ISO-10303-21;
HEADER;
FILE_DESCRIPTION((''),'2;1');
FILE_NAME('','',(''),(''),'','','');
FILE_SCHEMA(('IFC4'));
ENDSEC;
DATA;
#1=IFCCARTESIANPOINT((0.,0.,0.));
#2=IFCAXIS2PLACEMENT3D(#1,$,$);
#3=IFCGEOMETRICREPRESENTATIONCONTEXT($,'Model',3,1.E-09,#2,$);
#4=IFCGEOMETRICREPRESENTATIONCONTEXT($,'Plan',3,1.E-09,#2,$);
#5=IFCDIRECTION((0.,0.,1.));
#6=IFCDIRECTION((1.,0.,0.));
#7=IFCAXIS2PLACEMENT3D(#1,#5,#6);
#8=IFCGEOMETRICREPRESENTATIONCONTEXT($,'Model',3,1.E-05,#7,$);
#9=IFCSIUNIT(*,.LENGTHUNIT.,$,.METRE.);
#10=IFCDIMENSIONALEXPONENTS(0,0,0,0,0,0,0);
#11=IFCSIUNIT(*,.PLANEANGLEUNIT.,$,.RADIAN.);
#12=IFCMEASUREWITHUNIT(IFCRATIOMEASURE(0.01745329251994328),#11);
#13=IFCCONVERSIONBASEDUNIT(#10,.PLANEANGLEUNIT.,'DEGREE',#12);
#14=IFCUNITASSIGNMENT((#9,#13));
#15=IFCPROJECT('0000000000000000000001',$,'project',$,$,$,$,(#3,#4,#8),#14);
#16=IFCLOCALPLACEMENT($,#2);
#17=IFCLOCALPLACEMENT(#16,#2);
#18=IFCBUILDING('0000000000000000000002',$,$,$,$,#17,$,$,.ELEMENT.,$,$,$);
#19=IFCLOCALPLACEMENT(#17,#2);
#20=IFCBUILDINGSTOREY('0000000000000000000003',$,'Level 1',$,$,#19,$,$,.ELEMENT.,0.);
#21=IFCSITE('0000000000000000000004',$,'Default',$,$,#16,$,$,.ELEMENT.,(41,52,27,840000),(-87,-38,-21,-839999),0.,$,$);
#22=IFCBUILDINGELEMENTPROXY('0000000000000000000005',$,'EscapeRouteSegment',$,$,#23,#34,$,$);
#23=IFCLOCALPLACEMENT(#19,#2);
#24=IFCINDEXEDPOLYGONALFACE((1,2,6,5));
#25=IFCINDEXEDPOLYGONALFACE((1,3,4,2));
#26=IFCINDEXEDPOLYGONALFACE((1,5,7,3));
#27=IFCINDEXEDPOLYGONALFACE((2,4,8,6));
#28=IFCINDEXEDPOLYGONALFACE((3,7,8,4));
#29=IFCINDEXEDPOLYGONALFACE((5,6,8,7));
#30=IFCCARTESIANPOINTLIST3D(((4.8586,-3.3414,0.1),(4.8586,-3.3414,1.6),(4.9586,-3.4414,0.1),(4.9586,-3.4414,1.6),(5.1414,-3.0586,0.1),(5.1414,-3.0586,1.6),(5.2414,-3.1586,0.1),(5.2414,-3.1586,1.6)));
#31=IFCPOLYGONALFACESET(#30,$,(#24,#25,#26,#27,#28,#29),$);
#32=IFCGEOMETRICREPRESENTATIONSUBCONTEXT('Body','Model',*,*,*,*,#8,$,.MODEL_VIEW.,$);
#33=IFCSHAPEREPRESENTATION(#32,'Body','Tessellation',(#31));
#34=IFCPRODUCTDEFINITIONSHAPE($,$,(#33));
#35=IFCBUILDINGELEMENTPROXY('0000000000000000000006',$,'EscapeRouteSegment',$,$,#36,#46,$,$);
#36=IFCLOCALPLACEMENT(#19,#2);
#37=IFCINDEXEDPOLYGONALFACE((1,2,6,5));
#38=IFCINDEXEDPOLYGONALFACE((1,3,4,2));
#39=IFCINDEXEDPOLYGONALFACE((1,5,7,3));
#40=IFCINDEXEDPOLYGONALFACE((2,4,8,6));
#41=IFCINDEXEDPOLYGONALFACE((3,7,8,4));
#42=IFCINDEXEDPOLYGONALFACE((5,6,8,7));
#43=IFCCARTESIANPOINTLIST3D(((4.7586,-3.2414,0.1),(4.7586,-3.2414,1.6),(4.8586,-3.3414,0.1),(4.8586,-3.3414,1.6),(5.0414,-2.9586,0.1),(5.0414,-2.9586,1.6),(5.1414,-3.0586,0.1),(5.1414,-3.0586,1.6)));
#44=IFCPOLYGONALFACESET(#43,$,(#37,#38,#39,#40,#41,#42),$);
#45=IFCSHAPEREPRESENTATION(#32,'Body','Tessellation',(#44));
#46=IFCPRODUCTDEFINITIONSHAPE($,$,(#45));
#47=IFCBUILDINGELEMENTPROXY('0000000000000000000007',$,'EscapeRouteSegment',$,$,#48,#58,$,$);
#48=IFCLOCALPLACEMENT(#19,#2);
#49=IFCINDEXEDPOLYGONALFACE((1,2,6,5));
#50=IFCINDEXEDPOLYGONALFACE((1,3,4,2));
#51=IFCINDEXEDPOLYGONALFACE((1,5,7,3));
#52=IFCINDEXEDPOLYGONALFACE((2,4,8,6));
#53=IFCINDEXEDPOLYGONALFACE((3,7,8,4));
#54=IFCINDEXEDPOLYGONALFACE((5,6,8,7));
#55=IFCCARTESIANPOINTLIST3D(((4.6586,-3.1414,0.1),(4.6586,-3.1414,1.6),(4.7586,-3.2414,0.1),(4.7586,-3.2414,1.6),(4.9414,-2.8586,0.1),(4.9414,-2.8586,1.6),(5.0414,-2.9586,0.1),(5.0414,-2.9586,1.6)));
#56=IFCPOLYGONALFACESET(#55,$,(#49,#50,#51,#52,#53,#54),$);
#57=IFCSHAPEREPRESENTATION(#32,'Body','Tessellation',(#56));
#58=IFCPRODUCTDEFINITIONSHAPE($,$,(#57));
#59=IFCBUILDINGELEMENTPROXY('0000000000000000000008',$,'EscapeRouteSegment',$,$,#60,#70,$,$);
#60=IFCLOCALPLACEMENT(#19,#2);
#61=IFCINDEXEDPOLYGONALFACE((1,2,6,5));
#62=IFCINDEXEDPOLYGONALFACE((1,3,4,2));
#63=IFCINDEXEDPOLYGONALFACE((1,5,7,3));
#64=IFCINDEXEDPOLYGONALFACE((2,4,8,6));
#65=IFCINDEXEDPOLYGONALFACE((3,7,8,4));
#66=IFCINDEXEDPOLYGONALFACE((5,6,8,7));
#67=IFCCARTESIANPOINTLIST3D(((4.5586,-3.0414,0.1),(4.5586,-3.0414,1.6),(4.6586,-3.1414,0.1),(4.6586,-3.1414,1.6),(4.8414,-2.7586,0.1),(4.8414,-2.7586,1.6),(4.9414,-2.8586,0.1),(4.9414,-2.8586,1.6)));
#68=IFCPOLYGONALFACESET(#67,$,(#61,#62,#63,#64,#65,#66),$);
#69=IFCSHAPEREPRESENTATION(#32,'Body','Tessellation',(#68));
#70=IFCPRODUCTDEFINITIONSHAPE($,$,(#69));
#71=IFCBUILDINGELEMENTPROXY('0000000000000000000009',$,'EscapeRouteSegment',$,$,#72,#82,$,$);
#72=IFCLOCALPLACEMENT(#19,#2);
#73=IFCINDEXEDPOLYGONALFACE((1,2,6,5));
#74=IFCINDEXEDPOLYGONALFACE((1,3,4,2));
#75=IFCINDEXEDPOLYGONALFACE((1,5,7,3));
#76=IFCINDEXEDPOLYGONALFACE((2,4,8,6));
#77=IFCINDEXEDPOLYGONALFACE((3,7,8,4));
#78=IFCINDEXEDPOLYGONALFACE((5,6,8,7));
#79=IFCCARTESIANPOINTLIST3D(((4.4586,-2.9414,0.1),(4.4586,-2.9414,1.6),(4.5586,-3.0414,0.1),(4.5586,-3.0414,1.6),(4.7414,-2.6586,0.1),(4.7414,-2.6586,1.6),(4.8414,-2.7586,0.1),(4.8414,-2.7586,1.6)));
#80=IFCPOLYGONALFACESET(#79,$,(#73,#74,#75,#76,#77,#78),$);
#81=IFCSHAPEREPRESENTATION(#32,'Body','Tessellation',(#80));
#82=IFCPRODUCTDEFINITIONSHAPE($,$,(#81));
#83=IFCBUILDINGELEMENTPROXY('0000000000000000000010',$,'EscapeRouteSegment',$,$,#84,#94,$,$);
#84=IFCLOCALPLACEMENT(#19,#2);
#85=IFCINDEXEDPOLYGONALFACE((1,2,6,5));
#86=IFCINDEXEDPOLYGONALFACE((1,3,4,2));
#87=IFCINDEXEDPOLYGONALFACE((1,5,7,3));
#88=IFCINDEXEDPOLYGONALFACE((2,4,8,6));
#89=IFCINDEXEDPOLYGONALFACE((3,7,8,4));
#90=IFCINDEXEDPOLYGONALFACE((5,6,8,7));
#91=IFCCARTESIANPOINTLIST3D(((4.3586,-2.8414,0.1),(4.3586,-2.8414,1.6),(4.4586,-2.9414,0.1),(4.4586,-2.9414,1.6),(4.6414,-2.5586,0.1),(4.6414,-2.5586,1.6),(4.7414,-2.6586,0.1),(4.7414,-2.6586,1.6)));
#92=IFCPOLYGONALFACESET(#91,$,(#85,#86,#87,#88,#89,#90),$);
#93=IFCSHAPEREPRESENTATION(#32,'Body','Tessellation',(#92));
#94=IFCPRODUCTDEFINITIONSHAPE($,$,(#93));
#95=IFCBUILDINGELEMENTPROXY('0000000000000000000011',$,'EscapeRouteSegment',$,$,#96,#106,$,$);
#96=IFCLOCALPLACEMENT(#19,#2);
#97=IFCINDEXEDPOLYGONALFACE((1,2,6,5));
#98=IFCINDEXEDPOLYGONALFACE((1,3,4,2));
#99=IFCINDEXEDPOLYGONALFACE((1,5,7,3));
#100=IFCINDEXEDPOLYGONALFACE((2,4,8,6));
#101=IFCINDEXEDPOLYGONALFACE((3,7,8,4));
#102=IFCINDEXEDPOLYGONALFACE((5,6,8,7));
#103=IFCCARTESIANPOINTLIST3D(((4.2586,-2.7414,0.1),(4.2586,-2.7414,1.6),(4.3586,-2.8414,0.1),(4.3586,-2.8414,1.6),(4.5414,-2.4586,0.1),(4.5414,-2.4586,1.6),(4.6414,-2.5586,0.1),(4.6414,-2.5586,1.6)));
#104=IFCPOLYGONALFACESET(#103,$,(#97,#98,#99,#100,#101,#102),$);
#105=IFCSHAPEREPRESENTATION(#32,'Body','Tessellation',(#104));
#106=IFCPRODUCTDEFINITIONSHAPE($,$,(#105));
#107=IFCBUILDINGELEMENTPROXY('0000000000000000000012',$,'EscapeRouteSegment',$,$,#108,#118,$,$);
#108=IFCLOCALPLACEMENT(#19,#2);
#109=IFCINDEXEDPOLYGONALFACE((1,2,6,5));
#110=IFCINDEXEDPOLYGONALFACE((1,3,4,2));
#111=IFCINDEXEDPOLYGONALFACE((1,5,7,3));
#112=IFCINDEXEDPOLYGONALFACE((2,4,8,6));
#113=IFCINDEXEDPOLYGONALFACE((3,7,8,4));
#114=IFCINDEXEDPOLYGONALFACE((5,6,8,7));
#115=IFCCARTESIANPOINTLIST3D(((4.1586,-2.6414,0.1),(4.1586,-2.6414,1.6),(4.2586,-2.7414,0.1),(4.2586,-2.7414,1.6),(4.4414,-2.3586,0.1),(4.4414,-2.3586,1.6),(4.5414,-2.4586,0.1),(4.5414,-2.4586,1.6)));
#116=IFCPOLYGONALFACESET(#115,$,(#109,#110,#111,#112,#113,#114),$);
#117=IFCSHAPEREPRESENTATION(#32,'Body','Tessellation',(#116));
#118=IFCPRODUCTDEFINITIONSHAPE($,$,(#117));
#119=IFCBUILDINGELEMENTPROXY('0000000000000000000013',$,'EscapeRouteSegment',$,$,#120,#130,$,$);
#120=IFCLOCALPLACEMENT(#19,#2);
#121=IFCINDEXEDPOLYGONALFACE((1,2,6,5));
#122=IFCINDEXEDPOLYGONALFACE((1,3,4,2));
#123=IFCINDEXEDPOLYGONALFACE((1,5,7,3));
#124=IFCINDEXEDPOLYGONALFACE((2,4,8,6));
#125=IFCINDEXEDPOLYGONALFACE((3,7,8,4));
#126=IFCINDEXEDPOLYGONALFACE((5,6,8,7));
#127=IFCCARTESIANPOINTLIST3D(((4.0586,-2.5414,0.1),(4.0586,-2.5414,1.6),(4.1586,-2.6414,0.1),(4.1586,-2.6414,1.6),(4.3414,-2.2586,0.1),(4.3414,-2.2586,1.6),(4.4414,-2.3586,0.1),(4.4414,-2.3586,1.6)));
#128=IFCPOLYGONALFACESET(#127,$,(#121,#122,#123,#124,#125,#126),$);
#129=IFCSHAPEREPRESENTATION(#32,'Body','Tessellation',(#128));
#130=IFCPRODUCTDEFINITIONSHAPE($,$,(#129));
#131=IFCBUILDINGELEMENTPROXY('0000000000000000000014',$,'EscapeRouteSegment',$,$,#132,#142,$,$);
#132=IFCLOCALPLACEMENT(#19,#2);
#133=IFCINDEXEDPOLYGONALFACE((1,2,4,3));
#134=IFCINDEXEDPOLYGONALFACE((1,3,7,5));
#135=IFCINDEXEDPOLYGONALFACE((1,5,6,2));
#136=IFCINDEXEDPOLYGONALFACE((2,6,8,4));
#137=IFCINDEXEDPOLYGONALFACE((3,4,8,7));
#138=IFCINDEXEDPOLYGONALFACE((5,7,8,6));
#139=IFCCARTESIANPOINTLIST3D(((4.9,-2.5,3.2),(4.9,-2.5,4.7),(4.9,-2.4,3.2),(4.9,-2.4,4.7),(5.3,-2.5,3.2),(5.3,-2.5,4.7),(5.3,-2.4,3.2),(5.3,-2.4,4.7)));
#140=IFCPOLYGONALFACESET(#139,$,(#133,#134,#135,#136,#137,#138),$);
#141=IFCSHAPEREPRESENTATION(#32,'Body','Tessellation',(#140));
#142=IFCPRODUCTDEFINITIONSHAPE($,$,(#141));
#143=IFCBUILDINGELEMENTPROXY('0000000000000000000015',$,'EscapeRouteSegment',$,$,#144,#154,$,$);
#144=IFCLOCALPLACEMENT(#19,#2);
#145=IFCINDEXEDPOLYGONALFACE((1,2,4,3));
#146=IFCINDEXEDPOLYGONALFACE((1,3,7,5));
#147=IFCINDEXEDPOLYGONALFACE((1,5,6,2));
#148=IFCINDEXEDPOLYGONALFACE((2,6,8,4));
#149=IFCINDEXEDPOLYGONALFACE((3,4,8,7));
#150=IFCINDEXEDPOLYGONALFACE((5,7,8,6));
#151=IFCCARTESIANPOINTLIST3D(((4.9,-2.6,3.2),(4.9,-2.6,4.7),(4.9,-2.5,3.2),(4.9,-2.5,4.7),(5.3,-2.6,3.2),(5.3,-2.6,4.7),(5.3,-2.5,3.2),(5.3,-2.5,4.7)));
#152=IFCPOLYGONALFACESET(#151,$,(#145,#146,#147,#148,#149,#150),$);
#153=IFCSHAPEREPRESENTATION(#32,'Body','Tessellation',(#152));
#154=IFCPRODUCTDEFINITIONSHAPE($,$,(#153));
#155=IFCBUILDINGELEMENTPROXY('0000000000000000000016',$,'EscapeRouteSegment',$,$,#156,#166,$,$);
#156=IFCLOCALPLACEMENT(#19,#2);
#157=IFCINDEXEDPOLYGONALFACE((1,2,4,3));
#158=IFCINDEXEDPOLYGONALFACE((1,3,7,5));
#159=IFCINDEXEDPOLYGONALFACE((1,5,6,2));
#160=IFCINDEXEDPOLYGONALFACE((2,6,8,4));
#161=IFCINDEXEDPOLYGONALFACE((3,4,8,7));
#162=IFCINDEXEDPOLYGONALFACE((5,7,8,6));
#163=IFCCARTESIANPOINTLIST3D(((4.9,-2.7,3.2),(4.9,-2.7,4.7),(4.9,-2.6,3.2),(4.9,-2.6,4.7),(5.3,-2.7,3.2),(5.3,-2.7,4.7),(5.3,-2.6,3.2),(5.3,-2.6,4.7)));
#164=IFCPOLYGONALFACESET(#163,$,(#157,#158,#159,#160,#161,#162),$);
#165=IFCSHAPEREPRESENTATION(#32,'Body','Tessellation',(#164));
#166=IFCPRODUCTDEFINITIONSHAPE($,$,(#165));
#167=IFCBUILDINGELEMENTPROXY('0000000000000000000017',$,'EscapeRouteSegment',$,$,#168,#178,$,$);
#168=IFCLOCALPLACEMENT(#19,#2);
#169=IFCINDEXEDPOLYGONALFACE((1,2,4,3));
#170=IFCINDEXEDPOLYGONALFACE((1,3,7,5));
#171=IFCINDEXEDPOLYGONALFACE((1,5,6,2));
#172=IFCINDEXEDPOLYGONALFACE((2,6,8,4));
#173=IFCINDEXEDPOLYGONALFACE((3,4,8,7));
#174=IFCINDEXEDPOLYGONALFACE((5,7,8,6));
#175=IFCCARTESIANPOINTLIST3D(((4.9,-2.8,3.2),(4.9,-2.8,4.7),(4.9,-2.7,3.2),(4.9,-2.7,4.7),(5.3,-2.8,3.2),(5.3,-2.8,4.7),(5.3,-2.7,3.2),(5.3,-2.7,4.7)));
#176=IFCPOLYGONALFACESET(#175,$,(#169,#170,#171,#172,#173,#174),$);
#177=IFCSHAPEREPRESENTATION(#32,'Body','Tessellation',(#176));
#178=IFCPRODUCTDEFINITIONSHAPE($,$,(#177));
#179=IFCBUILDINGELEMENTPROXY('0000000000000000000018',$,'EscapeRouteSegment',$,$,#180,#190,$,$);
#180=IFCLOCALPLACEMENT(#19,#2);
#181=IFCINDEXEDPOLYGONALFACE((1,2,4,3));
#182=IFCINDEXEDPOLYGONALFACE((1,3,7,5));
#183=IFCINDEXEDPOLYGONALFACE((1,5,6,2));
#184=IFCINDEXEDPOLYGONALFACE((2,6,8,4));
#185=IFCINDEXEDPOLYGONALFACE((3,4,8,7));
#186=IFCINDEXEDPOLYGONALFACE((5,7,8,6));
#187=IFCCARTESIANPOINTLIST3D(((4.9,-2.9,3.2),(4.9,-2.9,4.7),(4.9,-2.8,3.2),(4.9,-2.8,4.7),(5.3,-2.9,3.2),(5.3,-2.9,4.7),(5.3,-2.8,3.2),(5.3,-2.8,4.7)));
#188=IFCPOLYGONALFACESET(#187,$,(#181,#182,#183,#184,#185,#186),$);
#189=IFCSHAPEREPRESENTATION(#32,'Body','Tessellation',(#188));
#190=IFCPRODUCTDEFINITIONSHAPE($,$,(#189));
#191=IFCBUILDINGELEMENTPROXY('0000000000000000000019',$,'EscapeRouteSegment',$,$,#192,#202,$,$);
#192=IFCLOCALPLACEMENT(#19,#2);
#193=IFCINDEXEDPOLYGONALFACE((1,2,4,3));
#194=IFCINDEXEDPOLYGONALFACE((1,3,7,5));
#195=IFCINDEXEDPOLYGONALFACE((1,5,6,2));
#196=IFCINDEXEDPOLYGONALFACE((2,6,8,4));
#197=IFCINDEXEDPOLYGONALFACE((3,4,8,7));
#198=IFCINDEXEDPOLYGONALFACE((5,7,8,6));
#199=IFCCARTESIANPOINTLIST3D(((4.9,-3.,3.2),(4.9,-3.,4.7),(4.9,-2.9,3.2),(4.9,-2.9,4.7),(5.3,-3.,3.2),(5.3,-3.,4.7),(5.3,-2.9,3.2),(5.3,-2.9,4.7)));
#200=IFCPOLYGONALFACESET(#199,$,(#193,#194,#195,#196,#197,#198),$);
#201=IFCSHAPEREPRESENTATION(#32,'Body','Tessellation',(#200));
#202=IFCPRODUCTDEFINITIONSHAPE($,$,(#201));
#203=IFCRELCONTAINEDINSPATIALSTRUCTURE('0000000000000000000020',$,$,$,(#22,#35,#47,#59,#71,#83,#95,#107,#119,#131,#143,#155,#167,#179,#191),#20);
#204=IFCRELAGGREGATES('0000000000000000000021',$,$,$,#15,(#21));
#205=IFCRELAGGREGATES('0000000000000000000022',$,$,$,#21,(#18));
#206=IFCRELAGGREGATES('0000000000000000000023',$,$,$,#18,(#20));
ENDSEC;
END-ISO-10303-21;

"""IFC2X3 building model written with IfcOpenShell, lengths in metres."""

from ifc_helpers import new_model, entity, si_unit, converted_unit, frame, origin, origin_with_axes, place, context, subcontext, project, spatial, polyline, outline, extrude, element, save


model = new_model("IFC2X3")

# Units and contexts
model_context_1 = context("Model", 3, precision=1e-09, world=origin())
plan_context = context("Plan", 3, precision=1e-09, world=origin())
model_context_2 = context("Model", 3, precision=1e-05, world=origin_with_axes())
body_context = subcontext(model_context_2, "Body", "Model", "MODEL_VIEW")
ifc_project = project(units=[si_unit("LENGTHUNIT", "METRE"), converted_unit("PLANEANGLEUNIT", "DEGREE", entity("IfcRatioMeasure", 0.01745329251994328), si_unit("PLANEANGLEUNIT", "RADIAN"), dimensions=[0, 0, 0, 0, 0, 0, 0])], contexts=[model_context_1, plan_context, model_context_2])

# Site, building, storey
site_placement = place(None, origin())
site = spatial("IfcSite", under=ifc_project, at=site_placement, Name="Default", CompositionType="ELEMENT", RefLatitude=(41, 52, 27, 840000), RefLongitude=(-87, -38, -21, -839999), RefElevation=0.0)
building_placement = place(site_placement, origin())
building = spatial("IfcBuilding", under=site, at=building_placement, CompositionType="ELEMENT")
storey_placement = place(building_placement, origin())
storey = spatial("IfcBuildingStorey", under=building, at=storey_placement, Name="Level 1", CompositionType="ELEMENT", Elevation=0.0)

# Building element proxies
proxy_1_placement = place(storey_placement, frame((5.1, -3.3, 0.1), z_axis=(0.0, 0.0, 1.0), x_axis=(-0.707107, 0.707107, 0.0)))
element("IfcBuildingElementProxy", 1, at=proxy_1_placement, inside=storey, Name="EscapeRouteSegment", context=body_context, shape_type="SweptSolid", body=[
    extrude(outline(polyline([(0.0, -0.2), (0.0, 0.2), (0.1414, 0.2), (0.1414, -0.2), (0.0, -0.2)])), origin_with_axes(), (0.0, 0.0, 1.0), 1.5),
])
proxy_2_placement = place(storey_placement, frame((5.0, -3.2, 0.1), z_axis=(0.0, 0.0, 1.0), x_axis=(-0.707106, 0.707108, 0.0)))
element("IfcBuildingElementProxy", 2, at=proxy_2_placement, inside=storey, Name="EscapeRouteSegment", context=body_context, shape_type="SweptSolid", body=[
    extrude(outline(polyline([(0.0, -0.2), (0.0, 0.2), (0.1414, 0.2), (0.1414, -0.2), (0.0, -0.2)])), origin_with_axes(), (0.0, 0.0, 1.0), 1.5),
])
proxy_3_placement = place(storey_placement, frame((4.9, -3.1, 0.1), z_axis=(0.0, 0.0, 1.0), x_axis=(-0.707107, 0.707107, 0.0)))
element("IfcBuildingElementProxy", 3, at=proxy_3_placement, inside=storey, Name="EscapeRouteSegment", context=body_context, shape_type="SweptSolid", body=[
    extrude(outline(polyline([(0.0, -0.2), (0.0, 0.2), (0.1414, 0.2), (0.1414, -0.2), (0.0, -0.2)])), origin_with_axes(), (0.0, 0.0, 1.0), 1.5),
])
proxy_4_placement = place(storey_placement, frame((4.8, -3.0, 0.1), z_axis=(0.0, 0.0, 1.0), x_axis=(-0.707108, 0.707105, 0.0)))
element("IfcBuildingElementProxy", 4, at=proxy_4_placement, inside=storey, Name="EscapeRouteSegment", context=body_context, shape_type="SweptSolid", body=[
    extrude(outline(polyline([(0.0, -0.2), (0.0, 0.2), (0.1414, 0.2), (0.1414, -0.2), (0.0, -0.2)])), origin_with_axes(), (0.0, 0.0, 1.0), 1.5),
])
proxy_5_placement = place(storey_placement, frame((4.7, -2.9, 0.1), z_axis=(0.0, 0.0, 1.0), x_axis=(-0.707106, 0.707108, 0.0)))
element("IfcBuildingElementProxy", 5, at=proxy_5_placement, inside=storey, Name="EscapeRouteSegment", context=body_context, shape_type="SweptSolid", body=[
    extrude(outline(polyline([(0.0, -0.2), (0.0, 0.2), (0.1414, 0.2), (0.1414, -0.2), (0.0, -0.2)])), origin_with_axes(), (0.0, 0.0, 1.0), 1.5),
])
proxy_6_placement = place(storey_placement, frame((4.6, -2.8, 0.1), z_axis=(0.0, 0.0, 1.0), x_axis=(-0.707107, 0.707107, 0.0)))
element("IfcBuildingElementProxy", 6, at=proxy_6_placement, inside=storey, Name="EscapeRouteSegment", context=body_context, shape_type="SweptSolid", body=[
    extrude(outline(polyline([(0.0, -0.2), (0.0, 0.2), (0.1414, 0.2), (0.1414, -0.2), (0.0, -0.2)])), origin_with_axes(), (0.0, 0.0, 1.0), 1.5),
])
proxy_7_placement = place(storey_placement, frame((4.5, -2.7, 0.1), z_axis=(0.0, 0.0, 1.0), x_axis=(-0.707106, 0.707108, 0.0)))
element("IfcBuildingElementProxy", 7, at=proxy_7_placement, inside=storey, Name="EscapeRouteSegment", context=body_context, shape_type="SweptSolid", body=[
    extrude(outline(polyline([(0.0, -0.2), (0.0, 0.2), (0.1414, 0.2), (0.1414, -0.2), (0.0, -0.2)])), origin_with_axes(), (0.0, 0.0, 1.0), 1.5),
])
proxy_8_placement = place(storey_placement, frame((4.4, -2.6, 0.1), z_axis=(0.0, 0.0, 1.0), x_axis=(-0.707107, 0.707107, 0.0)))
element("IfcBuildingElementProxy", 8, at=proxy_8_placement, inside=storey, Name="EscapeRouteSegment", context=body_context, shape_type="SweptSolid", body=[
    extrude(outline(polyline([(0.0, -0.2), (0.0, 0.2), (0.1414, 0.2), (0.1414, -0.2), (0.0, -0.2)])), origin_with_axes(), (0.0, 0.0, 1.0), 1.5),
])
proxy_9_placement = place(storey_placement, frame((4.3, -2.5, 0.1), z_axis=(0.0, 0.0, 1.0), x_axis=(-0.707108, 0.707105, 0.0)))
element("IfcBuildingElementProxy", 9, at=proxy_9_placement, inside=storey, Name="EscapeRouteSegment", context=body_context, shape_type="SweptSolid", body=[
    extrude(outline(polyline([(0.0, -0.2), (0.0, 0.2), (0.1414, 0.2), (0.1414, -0.2), (0.0, -0.2)])), origin_with_axes(), (0.0, 0.0, 1.0), 1.5),
])
for number, where, z_axis, x_axis, name in (
    (10, (5.1, -2.4, 3.2), (0.0, 0.0, 1.0), (0.0, -1.0, 0.0), "EscapeRouteSegment"),
    (11, (5.1, -2.5, 3.2), (0.0, 0.0, 1.0), (0.0, -1.0, 0.0), "EscapeRouteSegment"),
):
    element("IfcBuildingElementProxy", number, at=place(storey_placement, frame(where, z_axis=z_axis, x_axis=x_axis)), inside=storey, Name=name, context=body_context, shape_type="SweptSolid", body=[
        extrude(outline(polyline([(0.0, -0.2), (0.0, 0.2), (0.1, 0.2), (0.1, -0.2), (0.0, -0.2)])), origin_with_axes(), (0.0, 0.0, 1.0), 1.5),
    ])
proxy_10_placement = place(storey_placement, frame((5.1, -2.6, 3.2), z_axis=(0.0, 0.0, 1.0), x_axis=(0.0, -1.0, 0.0)))
element("IfcBuildingElementProxy", 12, at=proxy_10_placement, inside=storey, Name="EscapeRouteSegment", context=body_context, shape_type="SweptSolid", body=[
    extrude(outline(polyline([(0.0, -0.2), (0.0, 0.2), (0.1, 0.2), (0.1, -0.2), (0.0, -0.2)])), origin_with_axes(), (0.0, 0.0, 1.0), 1.5),
])
proxy_11_placement = place(storey_placement, frame((5.1, -2.7, 3.2), z_axis=(0.0, 0.0, 1.0), x_axis=(0.0, -1.0, 0.0)))
element("IfcBuildingElementProxy", 13, at=proxy_11_placement, inside=storey, Name="EscapeRouteSegment", context=body_context, shape_type="SweptSolid", body=[
    extrude(outline(polyline([(0.0, -0.2), (0.0, 0.2), (0.1, 0.2), (0.1, -0.2), (0.0, -0.2)])), origin_with_axes(), (0.0, 0.0, 1.0), 1.5),
])
proxy_12_placement = place(storey_placement, frame((5.1, -2.8, 3.2), z_axis=(0.0, 0.0, 1.0), x_axis=(0.0, -1.0, 0.0)))
element("IfcBuildingElementProxy", 14, at=proxy_12_placement, inside=storey, Name="EscapeRouteSegment", context=body_context, shape_type="SweptSolid", body=[
    extrude(outline(polyline([(0.0, -0.2), (0.0, 0.2), (0.1, 0.2), (0.1, -0.2), (0.0, -0.2)])), origin_with_axes(), (0.0, 0.0, 1.0), 1.5),
])
for number, where, z_axis, x_axis, name in (
    (15, (5.1, -2.9, 3.2), (0.0, 0.0, 1.0), (0.0, -1.0, 0.0), "EscapeRouteSegment"),
):
    element("IfcBuildingElementProxy", number, at=place(storey_placement, frame(where, z_axis=z_axis, x_axis=x_axis)), inside=storey, Name=name, context=body_context, shape_type="SweptSolid", body=[
        extrude(outline(polyline([(0.0, -0.2), (0.0, 0.2), (0.1, 0.2), (0.1, -0.2), (0.0, -0.2)])), origin_with_axes(), (0.0, 0.0, 1.0), 1.5),
    ])

save(model, "model.ifc")
